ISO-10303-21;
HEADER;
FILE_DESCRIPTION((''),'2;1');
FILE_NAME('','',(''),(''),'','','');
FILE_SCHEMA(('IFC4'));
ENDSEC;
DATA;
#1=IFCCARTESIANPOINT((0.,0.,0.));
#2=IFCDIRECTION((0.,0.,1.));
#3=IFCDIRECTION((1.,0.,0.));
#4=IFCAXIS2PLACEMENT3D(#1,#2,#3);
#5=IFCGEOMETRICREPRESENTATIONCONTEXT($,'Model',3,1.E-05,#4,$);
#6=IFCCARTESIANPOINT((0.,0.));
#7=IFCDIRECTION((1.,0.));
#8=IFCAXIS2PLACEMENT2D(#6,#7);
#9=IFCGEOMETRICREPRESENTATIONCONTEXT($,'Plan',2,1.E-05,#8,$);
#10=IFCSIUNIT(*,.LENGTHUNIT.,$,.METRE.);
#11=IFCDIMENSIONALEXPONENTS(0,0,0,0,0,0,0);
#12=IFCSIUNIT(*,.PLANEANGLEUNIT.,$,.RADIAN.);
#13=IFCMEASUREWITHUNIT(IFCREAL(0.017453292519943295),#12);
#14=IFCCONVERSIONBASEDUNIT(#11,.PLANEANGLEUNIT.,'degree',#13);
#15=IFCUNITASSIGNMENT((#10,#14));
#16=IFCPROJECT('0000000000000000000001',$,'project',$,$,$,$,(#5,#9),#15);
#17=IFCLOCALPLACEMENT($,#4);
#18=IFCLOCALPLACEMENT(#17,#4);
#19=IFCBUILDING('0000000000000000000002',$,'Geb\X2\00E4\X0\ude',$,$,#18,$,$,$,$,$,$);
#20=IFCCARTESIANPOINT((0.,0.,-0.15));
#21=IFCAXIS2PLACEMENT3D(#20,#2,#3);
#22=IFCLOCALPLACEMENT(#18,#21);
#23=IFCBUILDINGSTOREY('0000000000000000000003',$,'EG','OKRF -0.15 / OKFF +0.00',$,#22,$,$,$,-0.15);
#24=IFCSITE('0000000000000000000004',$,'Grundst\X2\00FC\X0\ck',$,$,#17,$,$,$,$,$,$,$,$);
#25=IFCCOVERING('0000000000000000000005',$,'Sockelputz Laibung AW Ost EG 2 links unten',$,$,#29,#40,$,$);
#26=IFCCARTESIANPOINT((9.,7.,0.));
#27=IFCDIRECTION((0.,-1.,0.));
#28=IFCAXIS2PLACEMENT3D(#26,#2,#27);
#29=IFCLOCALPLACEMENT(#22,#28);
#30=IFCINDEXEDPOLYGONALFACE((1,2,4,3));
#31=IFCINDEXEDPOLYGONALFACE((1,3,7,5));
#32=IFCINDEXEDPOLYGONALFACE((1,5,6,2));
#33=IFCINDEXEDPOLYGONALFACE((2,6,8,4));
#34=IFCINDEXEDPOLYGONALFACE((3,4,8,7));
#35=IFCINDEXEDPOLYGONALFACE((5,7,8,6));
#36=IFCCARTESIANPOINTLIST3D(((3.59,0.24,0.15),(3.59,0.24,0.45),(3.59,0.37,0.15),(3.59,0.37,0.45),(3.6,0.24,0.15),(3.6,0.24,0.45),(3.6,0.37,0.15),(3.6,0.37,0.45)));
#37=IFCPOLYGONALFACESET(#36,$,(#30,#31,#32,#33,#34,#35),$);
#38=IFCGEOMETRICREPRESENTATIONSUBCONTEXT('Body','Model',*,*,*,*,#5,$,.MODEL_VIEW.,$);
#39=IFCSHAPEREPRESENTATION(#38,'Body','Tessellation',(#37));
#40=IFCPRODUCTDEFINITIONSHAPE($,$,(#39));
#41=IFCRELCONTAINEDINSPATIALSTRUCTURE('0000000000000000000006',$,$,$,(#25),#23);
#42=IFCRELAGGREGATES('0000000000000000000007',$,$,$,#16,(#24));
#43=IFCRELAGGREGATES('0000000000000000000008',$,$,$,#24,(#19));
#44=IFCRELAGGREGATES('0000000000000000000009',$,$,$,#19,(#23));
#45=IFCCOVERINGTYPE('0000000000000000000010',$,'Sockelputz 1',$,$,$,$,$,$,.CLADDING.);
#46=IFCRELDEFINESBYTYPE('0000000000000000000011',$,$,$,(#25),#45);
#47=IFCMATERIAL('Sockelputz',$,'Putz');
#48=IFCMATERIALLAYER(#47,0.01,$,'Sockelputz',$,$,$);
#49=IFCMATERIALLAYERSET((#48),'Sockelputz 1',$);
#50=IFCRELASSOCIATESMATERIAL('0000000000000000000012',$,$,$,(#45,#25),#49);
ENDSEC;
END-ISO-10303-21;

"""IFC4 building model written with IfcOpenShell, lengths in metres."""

from ifc_helpers import new_model, entity, si_unit, converted_unit, frame, origin_with_axes, origin_2d_with_axis, place, context, subcontext, project, spatial, polyline, outline, extrude, material, layer, layer_set, layer_usage, type_object, element, save


model = new_model("IFC4")

# Units and contexts
model_context = context("Model", 3, precision=1e-05, world=origin_with_axes())
plan_context = context("Plan", 2, precision=1e-05, world=origin_2d_with_axis())
body_context_1 = subcontext(model_context, "Body", "Model", "MODEL_VIEW")
ifc_project = project(units=[si_unit("LENGTHUNIT", "METRE"), converted_unit("PLANEANGLEUNIT", "degree", entity("IfcReal", 0.017453292519943295), si_unit("PLANEANGLEUNIT", "RADIAN"), dimensions=[0, 0, 0, 0, 0, 0, 0])], contexts=[model_context, plan_context])

# Site, building, storey
site_placement = place(None, origin_with_axes())
site = spatial("IfcSite", under=ifc_project, at=site_placement, Name="Grundstück")
building_placement = place(site_placement, origin_with_axes())
building = spatial("IfcBuilding", under=site, at=building_placement, Name="Gebäude")
storey_placement = place(building_placement, frame((0.0, 0.0, -0.15), z_axis=(0.0, 0.0, 1.0), x_axis=(1.0, 0.0, 0.0)))
storey = spatial("IfcBuildingStorey", under=building, at=storey_placement, Name="EG", Description="OKRF -0.15 / OKFF +0.00", Elevation=-0.15)

# Covering
ifc_material_1 = material(Name="Sockelputz", Category="Putz")
ifc_layer_1 = layer(ifc_material_1, 0.01, Name="Sockelputz")
ifc_layer_set_1 = layer_set([ifc_layer_1], Name="Sockelputz 1")
covering_type_1 = type_object("IfcCoveringType", Name="Sockelputz 1", PredefinedType="CLADDING", material=ifc_layer_set_1)
ifc_layer_usage_1 = layer_usage(ifc_layer_set_1, "AXIS1", "POSITIVE", 3.59)
covering_1_placement = place(storey_placement, frame((9.0, 7.0, 0.0), z_axis=(0.0, 0.0, 1.0), x_axis=(0.0, -1.0, 0.0)))
element("IfcCovering", 1, at=covering_1_placement, inside=storey, type_object=covering_type_1, material=ifc_layer_usage_1, Name="Sockelputz Laibung AW Ost EG 2 links unten", context=body_context_1, shape_type="SweptSolid", body=[
    extrude(outline(polyline([(0.24, 0.15), (0.37, 0.15), (0.37, 0.45), (0.24, 0.45), (0.24, 0.15)])), frame((3.59, 0.0, 0.0), z_axis=(1.0, 0.0, 0.0), x_axis=(0.0, 1.0, 0.0)), (0.0, 0.0, 1.0), 0.01),
])

save(model, "model.ifc")
